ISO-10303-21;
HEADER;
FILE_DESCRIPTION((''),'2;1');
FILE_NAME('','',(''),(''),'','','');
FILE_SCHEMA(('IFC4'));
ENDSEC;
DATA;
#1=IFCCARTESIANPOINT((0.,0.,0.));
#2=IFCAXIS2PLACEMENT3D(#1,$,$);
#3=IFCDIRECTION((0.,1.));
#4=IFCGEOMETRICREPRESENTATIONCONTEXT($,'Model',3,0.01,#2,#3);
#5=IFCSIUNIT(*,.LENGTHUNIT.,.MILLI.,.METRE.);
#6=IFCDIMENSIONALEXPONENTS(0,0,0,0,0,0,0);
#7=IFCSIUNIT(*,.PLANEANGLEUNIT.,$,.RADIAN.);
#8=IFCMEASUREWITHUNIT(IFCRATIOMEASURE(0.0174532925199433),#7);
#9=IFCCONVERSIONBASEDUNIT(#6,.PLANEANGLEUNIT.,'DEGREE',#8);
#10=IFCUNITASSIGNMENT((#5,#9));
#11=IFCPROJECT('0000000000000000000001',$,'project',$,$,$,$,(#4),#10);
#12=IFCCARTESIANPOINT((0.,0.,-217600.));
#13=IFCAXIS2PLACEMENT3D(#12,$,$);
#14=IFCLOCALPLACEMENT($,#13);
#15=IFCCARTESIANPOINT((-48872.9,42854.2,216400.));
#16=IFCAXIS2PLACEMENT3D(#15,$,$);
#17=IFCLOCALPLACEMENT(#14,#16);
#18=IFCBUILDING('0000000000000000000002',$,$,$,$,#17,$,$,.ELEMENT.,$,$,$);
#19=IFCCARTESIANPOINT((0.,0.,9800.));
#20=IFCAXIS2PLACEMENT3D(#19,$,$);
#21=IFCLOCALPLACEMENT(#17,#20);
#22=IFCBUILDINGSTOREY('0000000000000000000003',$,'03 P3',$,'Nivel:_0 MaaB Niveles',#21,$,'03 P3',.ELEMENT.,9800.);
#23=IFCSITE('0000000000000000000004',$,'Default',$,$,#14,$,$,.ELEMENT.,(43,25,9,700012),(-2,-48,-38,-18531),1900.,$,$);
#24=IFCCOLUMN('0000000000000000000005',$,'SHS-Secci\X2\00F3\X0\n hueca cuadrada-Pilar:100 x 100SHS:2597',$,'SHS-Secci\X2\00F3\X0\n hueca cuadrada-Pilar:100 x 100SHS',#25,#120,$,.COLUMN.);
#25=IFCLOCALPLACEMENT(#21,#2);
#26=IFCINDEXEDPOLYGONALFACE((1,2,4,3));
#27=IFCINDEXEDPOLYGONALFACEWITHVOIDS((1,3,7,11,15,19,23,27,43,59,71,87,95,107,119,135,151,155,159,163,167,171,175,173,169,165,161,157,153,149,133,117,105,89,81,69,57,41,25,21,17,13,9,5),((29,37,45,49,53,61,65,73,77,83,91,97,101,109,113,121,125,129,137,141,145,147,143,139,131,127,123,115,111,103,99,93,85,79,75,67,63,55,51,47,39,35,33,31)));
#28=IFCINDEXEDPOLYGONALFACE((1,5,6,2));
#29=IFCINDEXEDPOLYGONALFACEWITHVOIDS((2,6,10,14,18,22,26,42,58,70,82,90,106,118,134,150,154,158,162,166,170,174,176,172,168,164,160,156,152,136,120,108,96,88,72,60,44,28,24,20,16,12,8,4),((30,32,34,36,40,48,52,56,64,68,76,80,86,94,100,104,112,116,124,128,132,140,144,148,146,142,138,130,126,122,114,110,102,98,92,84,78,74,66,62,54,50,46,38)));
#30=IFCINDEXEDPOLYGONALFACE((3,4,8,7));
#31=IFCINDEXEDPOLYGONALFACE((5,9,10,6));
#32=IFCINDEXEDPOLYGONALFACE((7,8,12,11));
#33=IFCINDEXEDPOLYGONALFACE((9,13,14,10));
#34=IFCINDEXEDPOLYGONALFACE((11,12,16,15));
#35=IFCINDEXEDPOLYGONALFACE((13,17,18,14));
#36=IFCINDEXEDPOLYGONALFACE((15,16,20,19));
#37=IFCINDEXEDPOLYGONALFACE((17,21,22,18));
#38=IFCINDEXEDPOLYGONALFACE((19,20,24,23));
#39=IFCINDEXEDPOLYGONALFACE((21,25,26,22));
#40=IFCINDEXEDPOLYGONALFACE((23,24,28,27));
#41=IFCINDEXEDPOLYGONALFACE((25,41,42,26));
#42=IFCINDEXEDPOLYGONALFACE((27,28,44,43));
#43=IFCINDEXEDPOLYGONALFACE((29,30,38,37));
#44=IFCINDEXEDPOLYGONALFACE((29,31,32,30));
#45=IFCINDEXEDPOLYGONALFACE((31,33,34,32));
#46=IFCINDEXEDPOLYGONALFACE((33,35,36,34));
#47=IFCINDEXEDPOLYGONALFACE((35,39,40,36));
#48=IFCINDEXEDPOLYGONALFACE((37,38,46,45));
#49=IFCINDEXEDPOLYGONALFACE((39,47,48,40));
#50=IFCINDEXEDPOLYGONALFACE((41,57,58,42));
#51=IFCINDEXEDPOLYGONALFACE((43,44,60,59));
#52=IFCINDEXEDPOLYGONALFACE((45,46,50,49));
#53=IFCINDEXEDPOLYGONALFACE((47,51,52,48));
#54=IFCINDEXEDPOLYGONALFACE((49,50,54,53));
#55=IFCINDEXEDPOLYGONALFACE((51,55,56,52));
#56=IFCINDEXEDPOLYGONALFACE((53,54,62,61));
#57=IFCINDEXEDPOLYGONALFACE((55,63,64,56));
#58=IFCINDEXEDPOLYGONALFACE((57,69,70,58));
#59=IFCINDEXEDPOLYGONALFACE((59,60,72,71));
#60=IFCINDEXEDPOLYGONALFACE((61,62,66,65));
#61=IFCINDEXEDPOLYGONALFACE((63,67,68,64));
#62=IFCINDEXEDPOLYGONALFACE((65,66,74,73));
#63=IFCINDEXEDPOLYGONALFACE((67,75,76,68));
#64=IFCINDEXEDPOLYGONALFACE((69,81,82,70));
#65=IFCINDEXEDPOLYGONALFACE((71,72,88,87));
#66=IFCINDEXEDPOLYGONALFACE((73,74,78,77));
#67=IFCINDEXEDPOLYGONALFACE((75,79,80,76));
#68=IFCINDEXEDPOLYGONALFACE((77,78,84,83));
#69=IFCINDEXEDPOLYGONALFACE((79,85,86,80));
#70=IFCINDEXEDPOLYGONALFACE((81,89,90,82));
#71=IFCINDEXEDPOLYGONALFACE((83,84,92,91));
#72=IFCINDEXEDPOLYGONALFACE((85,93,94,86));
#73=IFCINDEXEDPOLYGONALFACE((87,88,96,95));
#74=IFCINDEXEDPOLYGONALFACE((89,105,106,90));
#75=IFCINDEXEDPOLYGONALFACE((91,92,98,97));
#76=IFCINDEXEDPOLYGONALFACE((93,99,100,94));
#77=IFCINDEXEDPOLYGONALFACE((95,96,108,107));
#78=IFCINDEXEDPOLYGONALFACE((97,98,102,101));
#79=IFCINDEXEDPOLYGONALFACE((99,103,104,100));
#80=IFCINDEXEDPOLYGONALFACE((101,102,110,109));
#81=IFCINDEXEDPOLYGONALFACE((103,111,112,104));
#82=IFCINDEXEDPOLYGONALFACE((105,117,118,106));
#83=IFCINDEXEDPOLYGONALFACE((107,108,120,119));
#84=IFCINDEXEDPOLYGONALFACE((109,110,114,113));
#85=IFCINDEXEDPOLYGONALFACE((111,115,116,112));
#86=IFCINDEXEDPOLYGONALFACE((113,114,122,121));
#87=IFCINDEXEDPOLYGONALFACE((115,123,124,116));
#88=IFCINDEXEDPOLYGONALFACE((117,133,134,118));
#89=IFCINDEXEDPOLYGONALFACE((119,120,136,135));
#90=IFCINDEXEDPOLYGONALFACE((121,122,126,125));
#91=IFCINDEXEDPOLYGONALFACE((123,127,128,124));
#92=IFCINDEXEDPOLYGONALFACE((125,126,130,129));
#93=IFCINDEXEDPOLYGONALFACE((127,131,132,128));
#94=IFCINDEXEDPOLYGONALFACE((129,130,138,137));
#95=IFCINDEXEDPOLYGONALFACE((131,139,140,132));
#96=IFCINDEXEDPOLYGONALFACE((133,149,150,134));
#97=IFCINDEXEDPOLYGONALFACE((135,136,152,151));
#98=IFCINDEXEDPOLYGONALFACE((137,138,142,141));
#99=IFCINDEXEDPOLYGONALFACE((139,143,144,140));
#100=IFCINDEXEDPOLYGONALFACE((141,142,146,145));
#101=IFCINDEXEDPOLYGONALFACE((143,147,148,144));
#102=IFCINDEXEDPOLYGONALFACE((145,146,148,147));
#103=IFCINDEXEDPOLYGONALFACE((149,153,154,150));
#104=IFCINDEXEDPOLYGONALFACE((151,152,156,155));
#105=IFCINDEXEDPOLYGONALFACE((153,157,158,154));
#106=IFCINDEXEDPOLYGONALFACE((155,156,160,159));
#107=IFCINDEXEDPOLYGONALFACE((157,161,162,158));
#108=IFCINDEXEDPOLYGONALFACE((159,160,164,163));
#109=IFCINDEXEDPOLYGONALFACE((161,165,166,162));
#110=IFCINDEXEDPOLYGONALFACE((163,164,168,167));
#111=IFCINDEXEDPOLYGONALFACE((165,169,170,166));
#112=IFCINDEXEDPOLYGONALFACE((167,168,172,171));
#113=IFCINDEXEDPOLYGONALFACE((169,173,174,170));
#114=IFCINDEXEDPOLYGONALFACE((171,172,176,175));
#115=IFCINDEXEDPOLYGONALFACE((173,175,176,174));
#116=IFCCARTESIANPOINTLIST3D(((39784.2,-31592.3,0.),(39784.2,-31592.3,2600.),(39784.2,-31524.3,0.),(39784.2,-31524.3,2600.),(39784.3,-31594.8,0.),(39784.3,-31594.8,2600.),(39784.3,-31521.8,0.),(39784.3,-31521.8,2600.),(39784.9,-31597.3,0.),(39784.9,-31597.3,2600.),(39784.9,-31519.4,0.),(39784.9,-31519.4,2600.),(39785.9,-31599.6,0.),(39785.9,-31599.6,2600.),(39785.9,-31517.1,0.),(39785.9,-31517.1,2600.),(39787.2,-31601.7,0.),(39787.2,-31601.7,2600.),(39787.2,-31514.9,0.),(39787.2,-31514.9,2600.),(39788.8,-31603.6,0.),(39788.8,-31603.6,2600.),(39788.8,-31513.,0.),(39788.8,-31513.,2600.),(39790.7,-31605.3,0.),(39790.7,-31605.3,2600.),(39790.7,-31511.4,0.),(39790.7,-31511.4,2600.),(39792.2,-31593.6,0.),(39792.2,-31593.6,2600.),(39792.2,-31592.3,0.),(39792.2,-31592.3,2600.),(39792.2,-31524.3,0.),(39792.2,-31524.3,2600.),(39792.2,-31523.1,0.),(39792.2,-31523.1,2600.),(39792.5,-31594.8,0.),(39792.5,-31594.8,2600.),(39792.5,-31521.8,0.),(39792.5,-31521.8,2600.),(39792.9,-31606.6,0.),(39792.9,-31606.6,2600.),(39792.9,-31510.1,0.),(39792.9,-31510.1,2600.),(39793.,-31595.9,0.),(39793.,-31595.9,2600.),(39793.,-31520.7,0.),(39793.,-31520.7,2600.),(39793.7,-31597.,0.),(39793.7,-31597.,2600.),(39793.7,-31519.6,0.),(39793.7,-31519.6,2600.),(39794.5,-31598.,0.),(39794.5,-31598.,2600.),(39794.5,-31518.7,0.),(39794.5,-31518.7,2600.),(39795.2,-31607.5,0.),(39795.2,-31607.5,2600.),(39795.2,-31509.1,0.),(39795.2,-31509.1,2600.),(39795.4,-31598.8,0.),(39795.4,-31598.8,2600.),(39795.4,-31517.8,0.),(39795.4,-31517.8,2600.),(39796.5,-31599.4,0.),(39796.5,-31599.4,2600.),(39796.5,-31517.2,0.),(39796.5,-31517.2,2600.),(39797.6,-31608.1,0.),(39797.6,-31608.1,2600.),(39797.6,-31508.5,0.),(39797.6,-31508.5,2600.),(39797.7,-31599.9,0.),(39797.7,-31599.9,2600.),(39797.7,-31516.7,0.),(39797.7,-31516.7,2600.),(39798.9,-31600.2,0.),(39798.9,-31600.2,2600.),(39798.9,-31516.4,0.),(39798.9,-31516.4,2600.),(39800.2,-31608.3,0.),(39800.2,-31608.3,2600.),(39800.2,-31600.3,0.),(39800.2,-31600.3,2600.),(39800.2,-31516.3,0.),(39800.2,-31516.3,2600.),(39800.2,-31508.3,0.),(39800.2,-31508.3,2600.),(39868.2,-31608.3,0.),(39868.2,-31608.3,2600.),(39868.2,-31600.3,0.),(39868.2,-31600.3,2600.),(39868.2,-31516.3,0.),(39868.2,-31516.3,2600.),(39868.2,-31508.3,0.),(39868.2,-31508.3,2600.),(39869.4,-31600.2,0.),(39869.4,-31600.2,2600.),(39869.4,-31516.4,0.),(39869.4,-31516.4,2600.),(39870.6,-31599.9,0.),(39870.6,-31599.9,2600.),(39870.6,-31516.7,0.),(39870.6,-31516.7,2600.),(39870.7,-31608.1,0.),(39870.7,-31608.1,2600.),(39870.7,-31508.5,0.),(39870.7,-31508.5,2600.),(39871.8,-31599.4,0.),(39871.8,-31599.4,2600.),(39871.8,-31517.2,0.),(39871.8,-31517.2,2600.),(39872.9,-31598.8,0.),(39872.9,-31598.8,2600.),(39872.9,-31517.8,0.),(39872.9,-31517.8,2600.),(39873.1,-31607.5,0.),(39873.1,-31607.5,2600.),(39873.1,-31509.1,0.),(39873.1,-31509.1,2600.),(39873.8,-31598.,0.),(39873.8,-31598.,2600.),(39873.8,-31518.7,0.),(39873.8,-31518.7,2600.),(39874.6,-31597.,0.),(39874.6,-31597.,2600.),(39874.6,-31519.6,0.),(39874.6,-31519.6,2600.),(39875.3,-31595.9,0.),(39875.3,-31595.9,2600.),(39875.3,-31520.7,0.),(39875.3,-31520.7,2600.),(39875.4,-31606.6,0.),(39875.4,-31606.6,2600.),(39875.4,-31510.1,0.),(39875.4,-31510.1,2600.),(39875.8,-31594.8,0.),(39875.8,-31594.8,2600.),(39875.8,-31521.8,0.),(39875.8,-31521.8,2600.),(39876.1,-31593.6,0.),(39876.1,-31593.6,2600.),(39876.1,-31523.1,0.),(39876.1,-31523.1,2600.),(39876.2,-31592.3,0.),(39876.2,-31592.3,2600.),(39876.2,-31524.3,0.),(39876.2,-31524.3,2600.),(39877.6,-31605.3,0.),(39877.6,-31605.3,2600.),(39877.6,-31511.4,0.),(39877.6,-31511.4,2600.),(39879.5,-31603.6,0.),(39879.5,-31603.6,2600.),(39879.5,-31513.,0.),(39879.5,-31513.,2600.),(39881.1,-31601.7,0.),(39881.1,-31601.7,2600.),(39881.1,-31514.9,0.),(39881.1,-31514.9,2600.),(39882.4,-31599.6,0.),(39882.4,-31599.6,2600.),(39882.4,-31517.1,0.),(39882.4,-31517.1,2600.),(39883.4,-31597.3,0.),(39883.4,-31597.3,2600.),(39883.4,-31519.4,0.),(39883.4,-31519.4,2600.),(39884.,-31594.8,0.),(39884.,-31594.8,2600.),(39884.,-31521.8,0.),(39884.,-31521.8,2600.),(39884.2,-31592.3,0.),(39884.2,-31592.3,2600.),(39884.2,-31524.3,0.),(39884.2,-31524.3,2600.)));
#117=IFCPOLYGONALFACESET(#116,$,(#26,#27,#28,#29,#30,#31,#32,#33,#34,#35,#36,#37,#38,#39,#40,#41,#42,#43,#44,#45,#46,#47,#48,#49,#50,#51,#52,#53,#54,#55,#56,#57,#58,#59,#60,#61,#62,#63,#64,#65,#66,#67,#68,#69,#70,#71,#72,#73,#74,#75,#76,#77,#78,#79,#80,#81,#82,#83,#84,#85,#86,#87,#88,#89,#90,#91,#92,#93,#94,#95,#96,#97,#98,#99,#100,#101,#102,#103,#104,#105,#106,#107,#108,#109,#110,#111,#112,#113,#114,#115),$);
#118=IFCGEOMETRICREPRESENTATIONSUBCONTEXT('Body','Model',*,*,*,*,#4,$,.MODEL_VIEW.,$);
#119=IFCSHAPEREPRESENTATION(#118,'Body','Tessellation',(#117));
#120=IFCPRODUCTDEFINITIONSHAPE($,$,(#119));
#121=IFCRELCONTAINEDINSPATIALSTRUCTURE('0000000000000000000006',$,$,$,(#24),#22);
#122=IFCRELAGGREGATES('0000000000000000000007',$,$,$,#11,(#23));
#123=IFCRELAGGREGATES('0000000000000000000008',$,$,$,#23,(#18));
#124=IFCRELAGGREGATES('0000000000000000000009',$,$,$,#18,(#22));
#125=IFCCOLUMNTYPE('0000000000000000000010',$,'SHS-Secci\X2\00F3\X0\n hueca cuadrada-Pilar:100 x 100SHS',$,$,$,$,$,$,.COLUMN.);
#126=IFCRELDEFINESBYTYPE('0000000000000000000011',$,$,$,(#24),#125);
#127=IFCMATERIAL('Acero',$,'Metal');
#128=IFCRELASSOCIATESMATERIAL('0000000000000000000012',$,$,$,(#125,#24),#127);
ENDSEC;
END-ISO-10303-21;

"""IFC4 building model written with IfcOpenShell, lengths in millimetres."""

from ifc_helpers import new_model, entity, si_unit, converted_unit, direction, frame, origin, place, context, subcontext, project, spatial, indexed_curve, outline, extrude, source, transform, mapped, material, type_object, type_shapes, element, save


model = new_model("IFC4")

# Units and contexts
model_context = context("Model", 3, precision=0.01, world=origin(), true_north=direction((0.0, 1.0)))
body_context = subcontext(model_context, "Body", "Model", "MODEL_VIEW")
ifc_project = project(units=[si_unit("LENGTHUNIT", "METRE", prefix="MILLI"), converted_unit("PLANEANGLEUNIT", "DEGREE", entity("IfcRatioMeasure", 0.0174532925199433), si_unit("PLANEANGLEUNIT", "RADIAN"), dimensions=[0, 0, 0, 0, 0, 0, 0])], contexts=[model_context])

# Site, building, storey
site_placement = place(None, frame((0.0, 0.0, -217600.0)))
site = spatial("IfcSite", under=ifc_project, at=site_placement, Name="Default", CompositionType="ELEMENT", RefLatitude=(43, 25, 9, 700012), RefLongitude=(-2, -48, -38, -18531), RefElevation=1900.0)
building_placement = place(site_placement, frame((-48872.9, 42854.2, 216400.0)))
building = spatial("IfcBuilding", under=site, at=building_placement, CompositionType="ELEMENT")
storey_placement = place(building_placement, frame((0.0, 0.0, 9800.0)))
storey = spatial("IfcBuildingStorey", under=building, at=storey_placement, Name="03 P3", ObjectType="Nivel:_0 MaaB Niveles", LongName="03 P3", CompositionType="ELEMENT", Elevation=9800.0)

# Column
ifc_material_1 = material(Name="Acero", Category="Metal")
column_type_1 = type_object("IfcColumnType", Name="SHS-Sección hueca cuadrada-Pilar:100 x 100SHS", PredefinedType="COLUMN", material=ifc_material_1)
shared_shape_1 = source(origin(), body_context, "Body", "SweptSolid", [
    extrude(outline(indexed_curve([(-34.0, -50.0), (34.0, -50.0), (36.5, -49.8), (38.9, -49.2), (41.3, -48.3), (43.4, -46.9), (45.3, -45.3), (46.9, -43.4), (48.3, -41.3), (49.2, -38.9), (49.8, -36.5), (50.0, -34.0), (50.0, 34.0), (49.8, 36.5), (49.2, 38.9), (48.3, 41.3), (46.9, 43.4), (45.3, 45.3), (43.4, 46.9), (41.3, 48.3), (38.9, 49.2), (36.5, 49.8), (34.0, 50.0), (-34.0, 50.0), (-36.5, 49.8), (-38.9, 49.2), (-41.3, 48.3), (-43.4, 46.9), (-45.3, 45.3), (-46.9, 43.4), (-48.3, 41.3), (-49.2, 38.9), (-49.8, 36.5), (-50.0, 34.0), (-50.0, -34.0), (-49.8, -36.5), (-49.2, -38.9), (-48.3, -41.3), (-46.9, -43.4), (-45.3, -45.3), (-43.4, -46.9), (-41.3, -48.3), (-38.9, -49.2), (-36.5, -49.8), (-34.0, -50.0)], self_intersect=False), holes=[indexed_curve([(-34.0, -42.0), (-35.3, -41.9), (-36.5, -41.6), (-37.6, -41.1), (-38.7, -40.5), (-39.7, -39.7), (-40.5, -38.7), (-41.1, -37.6), (-41.6, -36.5), (-41.9, -35.3), (-42.0, -34.0), (-42.0, 34.0), (-41.9, 35.3), (-41.6, 36.5), (-41.1, 37.6), (-40.5, 38.7), (-39.7, 39.7), (-38.7, 40.5), (-37.6, 41.1), (-36.5, 41.6), (-35.3, 41.9), (-34.0, 42.0), (34.0, 42.0), (35.3, 41.9), (36.5, 41.6), (37.6, 41.1), (38.7, 40.5), (39.7, 39.7), (40.5, 38.7), (41.1, 37.6), (41.6, 36.5), (41.9, 35.3), (42.0, 34.0), (42.0, -34.0), (41.9, -35.3), (41.6, -36.5), (41.1, -37.6), (40.5, -38.7), (39.7, -39.7), (38.7, -40.5), (37.6, -41.1), (36.5, -41.6), (35.3, -41.9), (34.0, -42.0), (-34.0, -42.0)], self_intersect=False)]), frame((0.0, 0.0, 9800.0), z_axis=(0.0, 0.0, 1.0), x_axis=(-1.0, 0.0, 0.0)), (0.0, 0.0, 1.0), 2600.0),
])
type_shapes(column_type_1, [shared_shape_1])
column_1_placement = place(storey_placement, frame((39834.2, -31558.3, -9800.0), z_axis=(0.0, 0.0, 1.0), x_axis=(0.0, -1.0, 0.0)))
element("IfcColumn", 1, at=column_1_placement, inside=storey, type_object=column_type_1, material=ifc_material_1, Name="SHS-Sección hueca cuadrada-Pilar:100 x 100SHS:2597", ObjectType="SHS-Sección hueca cuadrada-Pilar:100 x 100SHS", PredefinedType="COLUMN", context=body_context, shape_type="MappedRepresentation", body=[
    mapped(shared_shape_1, transform((0.0, 0.0, 0.0), scale=1.0)),
])

save(model, "model.ifc")
